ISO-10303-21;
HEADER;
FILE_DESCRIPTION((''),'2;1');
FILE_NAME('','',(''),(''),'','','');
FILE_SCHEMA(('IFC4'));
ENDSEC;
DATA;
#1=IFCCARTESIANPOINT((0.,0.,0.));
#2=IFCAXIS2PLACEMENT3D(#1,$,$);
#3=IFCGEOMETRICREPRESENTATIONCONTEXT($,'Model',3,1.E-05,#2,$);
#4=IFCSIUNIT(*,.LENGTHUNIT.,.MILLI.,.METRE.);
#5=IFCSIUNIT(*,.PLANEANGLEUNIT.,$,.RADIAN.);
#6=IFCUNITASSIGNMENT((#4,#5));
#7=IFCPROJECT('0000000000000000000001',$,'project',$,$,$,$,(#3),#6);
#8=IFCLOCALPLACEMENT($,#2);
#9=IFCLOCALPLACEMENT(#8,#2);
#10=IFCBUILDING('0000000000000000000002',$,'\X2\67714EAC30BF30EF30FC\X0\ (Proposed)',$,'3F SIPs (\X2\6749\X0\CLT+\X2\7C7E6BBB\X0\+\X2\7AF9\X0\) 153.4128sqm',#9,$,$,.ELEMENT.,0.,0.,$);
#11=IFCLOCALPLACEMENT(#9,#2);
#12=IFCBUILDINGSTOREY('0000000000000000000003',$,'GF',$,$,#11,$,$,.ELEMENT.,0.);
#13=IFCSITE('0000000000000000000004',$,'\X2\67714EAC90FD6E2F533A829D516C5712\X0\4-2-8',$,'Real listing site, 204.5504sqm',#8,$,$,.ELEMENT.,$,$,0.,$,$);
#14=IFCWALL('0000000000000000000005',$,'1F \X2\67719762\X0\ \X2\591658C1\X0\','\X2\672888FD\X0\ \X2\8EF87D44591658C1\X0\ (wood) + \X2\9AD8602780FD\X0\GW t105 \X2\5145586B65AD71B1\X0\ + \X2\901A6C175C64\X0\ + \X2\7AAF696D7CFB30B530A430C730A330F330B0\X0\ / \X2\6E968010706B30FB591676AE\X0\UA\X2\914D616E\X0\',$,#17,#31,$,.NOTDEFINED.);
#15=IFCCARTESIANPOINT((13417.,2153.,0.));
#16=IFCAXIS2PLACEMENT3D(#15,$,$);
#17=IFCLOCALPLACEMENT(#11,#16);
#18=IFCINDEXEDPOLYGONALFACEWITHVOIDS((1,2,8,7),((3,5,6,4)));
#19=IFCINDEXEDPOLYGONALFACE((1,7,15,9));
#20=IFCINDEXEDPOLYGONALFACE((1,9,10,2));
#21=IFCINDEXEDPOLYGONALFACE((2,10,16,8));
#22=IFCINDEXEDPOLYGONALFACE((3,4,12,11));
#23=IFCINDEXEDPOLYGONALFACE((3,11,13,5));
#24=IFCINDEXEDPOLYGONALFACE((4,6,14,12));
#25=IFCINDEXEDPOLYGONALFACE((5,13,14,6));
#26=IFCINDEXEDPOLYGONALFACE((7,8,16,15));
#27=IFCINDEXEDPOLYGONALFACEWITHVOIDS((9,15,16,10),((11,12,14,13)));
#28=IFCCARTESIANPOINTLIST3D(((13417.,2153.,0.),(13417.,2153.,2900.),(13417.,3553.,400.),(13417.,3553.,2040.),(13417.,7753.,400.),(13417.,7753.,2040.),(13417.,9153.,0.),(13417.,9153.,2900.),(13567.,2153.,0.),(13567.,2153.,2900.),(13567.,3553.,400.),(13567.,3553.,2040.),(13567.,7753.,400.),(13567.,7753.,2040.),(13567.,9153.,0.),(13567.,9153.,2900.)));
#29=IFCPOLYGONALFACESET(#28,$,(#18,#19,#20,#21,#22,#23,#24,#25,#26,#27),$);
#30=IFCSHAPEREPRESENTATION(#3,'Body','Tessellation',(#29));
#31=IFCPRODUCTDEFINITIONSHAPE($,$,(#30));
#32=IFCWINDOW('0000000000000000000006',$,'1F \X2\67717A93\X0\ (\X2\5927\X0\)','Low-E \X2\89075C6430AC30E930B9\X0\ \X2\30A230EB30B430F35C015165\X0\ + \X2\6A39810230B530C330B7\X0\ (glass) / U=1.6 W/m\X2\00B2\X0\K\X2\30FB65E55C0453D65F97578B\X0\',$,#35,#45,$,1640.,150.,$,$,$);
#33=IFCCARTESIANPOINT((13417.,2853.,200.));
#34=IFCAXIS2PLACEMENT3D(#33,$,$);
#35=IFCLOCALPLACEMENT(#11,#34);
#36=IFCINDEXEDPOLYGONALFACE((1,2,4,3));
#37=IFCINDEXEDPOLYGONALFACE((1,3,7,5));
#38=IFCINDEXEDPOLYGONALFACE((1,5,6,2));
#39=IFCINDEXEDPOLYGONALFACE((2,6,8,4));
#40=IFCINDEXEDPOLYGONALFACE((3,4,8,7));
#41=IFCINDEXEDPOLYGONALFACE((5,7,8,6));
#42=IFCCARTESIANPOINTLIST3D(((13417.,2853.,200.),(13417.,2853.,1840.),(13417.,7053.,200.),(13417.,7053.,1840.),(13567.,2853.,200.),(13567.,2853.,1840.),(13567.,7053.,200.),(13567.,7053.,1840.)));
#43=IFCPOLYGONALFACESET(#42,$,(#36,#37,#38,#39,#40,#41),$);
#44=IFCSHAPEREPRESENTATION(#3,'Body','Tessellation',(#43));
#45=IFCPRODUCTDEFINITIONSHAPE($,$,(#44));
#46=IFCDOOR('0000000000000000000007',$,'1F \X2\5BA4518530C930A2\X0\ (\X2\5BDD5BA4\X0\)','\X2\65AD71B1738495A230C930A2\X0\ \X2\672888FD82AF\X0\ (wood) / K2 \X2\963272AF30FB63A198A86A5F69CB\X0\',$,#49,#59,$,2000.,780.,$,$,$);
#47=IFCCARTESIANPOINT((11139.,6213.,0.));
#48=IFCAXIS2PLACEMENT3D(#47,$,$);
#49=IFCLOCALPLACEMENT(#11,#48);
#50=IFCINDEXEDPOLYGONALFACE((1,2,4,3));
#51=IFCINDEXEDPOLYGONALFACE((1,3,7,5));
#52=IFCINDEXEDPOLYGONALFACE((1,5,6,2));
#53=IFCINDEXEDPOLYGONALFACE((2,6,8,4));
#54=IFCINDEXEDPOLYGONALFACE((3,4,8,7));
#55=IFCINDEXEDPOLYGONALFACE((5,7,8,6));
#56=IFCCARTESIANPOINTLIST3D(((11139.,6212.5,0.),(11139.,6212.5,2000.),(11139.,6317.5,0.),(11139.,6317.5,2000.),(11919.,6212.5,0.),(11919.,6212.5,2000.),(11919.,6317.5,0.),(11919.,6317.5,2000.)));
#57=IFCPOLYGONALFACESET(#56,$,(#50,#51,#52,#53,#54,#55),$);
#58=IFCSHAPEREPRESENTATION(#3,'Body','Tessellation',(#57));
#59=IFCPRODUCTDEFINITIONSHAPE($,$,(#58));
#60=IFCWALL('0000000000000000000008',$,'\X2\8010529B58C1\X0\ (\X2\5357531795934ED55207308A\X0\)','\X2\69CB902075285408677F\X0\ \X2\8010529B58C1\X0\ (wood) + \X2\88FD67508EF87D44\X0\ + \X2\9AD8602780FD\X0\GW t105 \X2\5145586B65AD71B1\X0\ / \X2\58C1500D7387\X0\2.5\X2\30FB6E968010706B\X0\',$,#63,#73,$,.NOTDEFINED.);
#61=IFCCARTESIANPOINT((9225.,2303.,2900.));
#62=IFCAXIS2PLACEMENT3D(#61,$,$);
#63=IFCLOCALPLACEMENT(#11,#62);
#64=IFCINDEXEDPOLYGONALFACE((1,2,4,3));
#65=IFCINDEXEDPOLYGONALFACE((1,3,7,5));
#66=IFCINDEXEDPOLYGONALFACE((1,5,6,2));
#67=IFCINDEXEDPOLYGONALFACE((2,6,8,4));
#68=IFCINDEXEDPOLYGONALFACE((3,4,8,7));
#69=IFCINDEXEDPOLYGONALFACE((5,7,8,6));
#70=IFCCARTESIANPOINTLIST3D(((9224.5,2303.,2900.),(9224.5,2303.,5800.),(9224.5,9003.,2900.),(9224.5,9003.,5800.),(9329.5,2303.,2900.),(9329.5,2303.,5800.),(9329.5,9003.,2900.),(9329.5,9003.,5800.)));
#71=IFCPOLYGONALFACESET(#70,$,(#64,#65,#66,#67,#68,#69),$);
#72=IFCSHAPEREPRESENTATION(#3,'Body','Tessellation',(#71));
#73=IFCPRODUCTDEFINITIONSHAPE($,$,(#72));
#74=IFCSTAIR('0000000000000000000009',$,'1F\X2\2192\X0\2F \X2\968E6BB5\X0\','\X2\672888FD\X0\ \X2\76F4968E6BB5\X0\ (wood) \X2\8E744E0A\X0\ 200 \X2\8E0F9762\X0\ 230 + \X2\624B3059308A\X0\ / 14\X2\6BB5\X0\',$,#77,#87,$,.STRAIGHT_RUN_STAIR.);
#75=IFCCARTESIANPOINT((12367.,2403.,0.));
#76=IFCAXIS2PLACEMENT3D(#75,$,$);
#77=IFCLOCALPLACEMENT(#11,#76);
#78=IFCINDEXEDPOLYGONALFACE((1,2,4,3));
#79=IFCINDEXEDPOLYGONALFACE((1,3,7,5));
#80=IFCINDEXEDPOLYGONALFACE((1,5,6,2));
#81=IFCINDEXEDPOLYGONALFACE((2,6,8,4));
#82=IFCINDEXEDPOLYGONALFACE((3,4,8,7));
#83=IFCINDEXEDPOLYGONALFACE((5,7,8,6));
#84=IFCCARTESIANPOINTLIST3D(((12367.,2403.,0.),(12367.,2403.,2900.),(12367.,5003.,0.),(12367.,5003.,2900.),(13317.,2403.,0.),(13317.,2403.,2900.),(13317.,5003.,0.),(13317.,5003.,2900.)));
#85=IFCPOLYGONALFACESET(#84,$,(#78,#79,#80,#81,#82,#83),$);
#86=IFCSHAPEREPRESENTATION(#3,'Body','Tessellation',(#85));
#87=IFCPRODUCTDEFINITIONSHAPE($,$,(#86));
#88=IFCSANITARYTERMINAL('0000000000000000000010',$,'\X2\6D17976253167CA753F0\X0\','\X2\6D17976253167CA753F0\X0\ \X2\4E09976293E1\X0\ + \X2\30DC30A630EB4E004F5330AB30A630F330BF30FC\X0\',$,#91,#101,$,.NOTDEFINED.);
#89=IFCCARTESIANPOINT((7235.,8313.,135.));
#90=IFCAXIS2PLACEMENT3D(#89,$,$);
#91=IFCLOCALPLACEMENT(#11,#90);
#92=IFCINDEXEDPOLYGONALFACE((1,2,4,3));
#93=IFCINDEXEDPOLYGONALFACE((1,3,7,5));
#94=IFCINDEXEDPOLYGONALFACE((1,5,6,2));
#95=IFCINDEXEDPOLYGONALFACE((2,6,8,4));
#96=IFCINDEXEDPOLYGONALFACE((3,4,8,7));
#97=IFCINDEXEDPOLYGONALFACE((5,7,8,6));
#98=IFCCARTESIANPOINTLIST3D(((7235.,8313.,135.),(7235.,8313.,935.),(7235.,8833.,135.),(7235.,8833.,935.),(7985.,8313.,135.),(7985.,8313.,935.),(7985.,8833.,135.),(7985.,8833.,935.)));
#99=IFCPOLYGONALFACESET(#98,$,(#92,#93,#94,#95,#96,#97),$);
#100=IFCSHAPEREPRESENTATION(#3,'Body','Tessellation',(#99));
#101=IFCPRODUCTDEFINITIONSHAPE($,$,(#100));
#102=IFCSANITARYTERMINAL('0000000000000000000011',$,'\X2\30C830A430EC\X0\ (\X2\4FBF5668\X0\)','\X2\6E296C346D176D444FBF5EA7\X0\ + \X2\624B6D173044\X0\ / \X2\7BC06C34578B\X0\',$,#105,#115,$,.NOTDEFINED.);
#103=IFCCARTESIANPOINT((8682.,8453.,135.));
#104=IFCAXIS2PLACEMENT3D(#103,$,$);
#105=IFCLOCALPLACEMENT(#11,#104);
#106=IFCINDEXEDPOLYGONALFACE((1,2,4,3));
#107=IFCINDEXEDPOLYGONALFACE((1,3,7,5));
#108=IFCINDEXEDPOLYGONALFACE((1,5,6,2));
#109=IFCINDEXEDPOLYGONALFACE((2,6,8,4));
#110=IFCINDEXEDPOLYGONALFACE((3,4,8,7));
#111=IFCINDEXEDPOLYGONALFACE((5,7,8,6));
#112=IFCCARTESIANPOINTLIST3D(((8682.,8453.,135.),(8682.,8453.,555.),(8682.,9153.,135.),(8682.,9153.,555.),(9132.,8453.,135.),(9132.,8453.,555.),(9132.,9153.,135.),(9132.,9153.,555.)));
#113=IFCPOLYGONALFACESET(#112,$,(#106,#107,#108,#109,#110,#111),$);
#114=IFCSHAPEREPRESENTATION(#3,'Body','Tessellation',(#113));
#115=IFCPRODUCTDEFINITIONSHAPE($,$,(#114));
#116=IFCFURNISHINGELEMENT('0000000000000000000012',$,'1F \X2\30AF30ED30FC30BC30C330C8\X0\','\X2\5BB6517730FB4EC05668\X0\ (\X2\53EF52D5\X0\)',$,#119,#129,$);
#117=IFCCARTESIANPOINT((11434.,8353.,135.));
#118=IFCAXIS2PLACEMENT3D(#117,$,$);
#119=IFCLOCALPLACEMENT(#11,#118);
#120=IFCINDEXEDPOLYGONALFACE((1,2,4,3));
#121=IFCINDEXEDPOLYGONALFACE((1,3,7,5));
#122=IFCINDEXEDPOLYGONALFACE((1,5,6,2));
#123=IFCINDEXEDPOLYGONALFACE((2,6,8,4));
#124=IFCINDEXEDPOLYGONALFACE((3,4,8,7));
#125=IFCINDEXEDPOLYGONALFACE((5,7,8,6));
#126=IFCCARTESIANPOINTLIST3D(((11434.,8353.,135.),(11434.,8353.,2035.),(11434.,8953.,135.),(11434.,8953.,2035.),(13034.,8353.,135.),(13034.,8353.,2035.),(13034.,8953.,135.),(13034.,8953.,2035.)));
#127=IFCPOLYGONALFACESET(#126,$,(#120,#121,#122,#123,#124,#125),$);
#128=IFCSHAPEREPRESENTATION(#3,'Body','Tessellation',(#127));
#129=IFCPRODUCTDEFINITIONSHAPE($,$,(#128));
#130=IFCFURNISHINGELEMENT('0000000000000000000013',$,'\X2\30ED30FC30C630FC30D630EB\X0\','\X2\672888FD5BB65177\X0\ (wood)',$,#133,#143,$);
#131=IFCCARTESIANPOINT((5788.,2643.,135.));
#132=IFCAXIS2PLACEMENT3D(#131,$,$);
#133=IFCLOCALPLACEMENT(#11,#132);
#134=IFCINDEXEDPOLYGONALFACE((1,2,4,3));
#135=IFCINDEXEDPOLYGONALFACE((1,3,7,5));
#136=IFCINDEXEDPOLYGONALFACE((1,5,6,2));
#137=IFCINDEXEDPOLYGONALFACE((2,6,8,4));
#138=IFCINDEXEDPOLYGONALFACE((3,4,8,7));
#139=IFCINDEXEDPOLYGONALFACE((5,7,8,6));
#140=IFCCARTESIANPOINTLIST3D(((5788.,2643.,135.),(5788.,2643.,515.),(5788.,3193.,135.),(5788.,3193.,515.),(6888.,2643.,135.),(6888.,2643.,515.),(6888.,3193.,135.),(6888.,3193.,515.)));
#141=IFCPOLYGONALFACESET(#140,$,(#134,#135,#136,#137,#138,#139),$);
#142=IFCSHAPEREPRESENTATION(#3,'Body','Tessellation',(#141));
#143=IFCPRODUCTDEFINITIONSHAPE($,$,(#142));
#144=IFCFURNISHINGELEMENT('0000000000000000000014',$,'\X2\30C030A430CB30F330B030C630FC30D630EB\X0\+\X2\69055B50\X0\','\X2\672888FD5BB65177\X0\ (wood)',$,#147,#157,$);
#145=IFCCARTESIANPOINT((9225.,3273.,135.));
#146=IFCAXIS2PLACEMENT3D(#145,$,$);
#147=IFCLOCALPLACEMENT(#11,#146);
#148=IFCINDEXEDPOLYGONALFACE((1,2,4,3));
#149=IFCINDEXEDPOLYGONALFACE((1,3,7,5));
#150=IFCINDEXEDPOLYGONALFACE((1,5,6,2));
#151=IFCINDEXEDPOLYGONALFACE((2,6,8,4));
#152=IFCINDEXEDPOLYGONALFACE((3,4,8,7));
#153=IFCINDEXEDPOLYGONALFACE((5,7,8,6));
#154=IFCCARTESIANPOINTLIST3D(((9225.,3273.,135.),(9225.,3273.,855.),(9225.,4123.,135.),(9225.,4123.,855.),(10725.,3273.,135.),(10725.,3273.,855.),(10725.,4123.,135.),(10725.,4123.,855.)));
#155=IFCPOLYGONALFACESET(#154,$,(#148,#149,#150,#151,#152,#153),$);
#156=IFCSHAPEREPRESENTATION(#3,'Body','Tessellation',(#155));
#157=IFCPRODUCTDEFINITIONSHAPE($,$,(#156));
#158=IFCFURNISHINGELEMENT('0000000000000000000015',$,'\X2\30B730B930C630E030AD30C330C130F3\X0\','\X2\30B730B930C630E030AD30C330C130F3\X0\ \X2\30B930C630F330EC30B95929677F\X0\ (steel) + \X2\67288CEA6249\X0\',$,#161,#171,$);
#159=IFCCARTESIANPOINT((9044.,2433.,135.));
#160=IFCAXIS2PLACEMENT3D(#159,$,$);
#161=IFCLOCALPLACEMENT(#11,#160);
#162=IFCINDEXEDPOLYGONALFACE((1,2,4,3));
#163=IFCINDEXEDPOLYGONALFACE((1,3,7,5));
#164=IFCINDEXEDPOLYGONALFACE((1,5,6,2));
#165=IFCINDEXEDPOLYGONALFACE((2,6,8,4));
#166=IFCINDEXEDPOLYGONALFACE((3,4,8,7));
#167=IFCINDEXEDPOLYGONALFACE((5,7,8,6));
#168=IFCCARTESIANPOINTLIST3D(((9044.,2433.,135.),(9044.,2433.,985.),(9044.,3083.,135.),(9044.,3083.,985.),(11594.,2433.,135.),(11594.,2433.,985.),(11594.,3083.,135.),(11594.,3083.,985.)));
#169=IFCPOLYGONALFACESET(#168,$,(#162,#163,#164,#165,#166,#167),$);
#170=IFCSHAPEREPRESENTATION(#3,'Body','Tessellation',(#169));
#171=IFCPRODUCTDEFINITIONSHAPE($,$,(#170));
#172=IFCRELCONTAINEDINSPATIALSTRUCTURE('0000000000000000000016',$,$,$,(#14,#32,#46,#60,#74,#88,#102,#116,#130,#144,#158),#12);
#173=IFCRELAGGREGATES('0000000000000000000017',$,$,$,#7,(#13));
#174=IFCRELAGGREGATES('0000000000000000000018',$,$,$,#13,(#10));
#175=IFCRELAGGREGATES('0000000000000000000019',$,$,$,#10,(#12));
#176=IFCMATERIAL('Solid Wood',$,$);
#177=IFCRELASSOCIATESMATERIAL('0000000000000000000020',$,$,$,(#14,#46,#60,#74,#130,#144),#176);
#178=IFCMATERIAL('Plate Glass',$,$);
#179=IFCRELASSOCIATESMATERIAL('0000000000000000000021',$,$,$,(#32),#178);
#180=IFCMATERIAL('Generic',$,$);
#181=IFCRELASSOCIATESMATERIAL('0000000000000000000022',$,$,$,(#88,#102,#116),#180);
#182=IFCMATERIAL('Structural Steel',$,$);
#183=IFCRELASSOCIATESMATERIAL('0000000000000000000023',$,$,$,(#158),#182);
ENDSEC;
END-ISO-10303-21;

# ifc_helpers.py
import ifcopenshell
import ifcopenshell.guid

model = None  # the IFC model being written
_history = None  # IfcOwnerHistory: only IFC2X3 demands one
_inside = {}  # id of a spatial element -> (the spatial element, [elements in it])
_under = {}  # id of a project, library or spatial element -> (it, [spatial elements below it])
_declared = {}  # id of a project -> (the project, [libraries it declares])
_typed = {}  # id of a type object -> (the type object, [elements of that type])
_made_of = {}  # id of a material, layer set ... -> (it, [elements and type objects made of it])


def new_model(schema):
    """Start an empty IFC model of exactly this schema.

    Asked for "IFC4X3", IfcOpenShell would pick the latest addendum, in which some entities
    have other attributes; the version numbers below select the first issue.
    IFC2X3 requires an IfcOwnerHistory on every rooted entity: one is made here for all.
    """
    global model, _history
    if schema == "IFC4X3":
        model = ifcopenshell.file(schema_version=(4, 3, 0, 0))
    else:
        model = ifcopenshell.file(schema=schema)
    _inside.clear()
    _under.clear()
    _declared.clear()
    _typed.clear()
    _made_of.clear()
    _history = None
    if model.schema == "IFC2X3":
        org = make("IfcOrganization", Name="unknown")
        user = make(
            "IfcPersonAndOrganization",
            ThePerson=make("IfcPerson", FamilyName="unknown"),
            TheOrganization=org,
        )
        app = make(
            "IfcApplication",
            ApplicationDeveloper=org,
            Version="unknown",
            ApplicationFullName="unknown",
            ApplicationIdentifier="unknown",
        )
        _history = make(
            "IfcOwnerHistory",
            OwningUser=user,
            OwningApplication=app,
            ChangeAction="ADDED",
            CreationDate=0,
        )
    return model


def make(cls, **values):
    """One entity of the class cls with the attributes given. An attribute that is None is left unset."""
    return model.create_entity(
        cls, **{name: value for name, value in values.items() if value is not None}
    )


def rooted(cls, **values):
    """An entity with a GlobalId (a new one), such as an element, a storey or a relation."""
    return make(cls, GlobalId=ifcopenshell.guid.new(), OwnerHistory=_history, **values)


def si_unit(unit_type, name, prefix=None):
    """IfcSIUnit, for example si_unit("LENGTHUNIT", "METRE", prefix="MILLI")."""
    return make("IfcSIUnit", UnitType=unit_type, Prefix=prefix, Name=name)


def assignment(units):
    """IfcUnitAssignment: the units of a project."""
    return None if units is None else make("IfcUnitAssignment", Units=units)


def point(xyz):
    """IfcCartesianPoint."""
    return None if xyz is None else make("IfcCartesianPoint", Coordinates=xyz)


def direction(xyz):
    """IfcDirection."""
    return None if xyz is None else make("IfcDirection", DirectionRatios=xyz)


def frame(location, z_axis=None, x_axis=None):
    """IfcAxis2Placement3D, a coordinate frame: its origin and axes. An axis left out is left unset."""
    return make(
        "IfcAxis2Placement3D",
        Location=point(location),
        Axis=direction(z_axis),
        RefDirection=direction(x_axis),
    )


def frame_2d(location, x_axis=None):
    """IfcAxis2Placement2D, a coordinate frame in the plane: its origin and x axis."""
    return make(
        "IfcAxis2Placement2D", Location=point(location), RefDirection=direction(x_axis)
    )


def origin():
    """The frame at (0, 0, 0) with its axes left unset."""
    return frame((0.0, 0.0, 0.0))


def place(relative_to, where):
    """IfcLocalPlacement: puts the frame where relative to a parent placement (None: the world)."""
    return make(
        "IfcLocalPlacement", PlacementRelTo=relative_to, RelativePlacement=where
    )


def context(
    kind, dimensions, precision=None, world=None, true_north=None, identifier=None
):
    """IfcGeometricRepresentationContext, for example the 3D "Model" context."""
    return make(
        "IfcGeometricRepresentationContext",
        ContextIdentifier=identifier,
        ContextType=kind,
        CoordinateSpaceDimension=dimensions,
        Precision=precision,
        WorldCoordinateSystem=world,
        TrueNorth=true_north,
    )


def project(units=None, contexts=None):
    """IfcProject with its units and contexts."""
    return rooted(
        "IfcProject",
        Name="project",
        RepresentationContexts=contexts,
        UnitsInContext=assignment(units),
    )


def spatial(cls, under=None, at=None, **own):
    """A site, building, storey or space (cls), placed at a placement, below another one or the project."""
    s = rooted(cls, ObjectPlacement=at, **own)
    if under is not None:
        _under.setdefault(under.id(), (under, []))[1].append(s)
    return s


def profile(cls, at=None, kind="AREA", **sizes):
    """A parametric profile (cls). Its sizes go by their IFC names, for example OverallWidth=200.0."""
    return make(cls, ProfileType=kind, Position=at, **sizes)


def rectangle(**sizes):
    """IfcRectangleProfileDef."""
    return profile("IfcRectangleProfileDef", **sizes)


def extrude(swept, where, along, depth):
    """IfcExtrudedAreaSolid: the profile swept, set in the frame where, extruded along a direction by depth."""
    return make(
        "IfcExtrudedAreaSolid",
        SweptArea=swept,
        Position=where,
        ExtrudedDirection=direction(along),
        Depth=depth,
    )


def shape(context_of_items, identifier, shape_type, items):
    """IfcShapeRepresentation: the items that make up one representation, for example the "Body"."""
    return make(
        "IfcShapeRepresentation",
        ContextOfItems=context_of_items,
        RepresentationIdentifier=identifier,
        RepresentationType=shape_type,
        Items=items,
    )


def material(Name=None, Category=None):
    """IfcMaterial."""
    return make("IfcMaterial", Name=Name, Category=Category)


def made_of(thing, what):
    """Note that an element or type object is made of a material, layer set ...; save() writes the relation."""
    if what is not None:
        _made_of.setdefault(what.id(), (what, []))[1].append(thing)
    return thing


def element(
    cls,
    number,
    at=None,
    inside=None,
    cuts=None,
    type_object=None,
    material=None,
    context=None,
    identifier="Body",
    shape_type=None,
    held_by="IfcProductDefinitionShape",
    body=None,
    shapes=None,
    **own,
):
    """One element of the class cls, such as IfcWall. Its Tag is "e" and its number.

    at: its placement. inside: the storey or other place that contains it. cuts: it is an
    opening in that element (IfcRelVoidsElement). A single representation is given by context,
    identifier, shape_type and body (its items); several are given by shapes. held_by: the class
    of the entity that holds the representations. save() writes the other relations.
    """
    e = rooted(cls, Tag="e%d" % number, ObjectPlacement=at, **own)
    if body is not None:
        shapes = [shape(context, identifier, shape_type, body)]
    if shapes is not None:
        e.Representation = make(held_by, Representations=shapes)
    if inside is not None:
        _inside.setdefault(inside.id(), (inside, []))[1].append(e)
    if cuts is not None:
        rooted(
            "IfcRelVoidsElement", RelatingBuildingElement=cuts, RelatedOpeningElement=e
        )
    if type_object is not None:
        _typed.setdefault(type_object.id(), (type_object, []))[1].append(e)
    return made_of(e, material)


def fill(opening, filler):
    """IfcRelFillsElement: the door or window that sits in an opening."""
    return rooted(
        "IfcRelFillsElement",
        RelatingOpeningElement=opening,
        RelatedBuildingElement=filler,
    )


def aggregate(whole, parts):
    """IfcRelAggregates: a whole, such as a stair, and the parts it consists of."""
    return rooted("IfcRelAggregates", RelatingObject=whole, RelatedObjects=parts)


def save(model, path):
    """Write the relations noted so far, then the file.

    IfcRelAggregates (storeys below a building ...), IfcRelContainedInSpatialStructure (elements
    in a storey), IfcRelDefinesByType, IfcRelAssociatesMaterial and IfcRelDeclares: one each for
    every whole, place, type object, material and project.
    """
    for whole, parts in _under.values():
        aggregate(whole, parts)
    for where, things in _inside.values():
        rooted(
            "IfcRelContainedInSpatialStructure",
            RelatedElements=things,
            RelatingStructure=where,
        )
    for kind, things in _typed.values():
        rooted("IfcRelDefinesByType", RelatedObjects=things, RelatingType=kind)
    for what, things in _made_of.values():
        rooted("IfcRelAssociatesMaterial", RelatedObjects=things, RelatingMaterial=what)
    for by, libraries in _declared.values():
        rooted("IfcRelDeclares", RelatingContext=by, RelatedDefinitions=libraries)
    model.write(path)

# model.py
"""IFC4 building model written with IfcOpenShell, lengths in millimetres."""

from ifc_helpers import new_model, si_unit, frame, frame_2d, origin, place, context, project, spatial, rectangle, extrude, material, element, fill, save


model = new_model("IFC4")

# Units and contexts
model_context = context("Model", 3, precision=1e-05, world=origin())
ifc_project = project(units=[si_unit("LENGTHUNIT", "METRE", prefix="MILLI"), si_unit("PLANEANGLEUNIT", "RADIAN")], contexts=[model_context])

# Site, building, storey
site_placement = place(None, origin())
site = spatial("IfcSite", under=ifc_project, at=site_placement, Name="東京都港区芝公園4-2-8", ObjectType="Real listing site, 204.5504sqm", CompositionType="ELEMENT", RefElevation=0.0)
building_placement = place(site_placement, origin())
building = spatial("IfcBuilding", under=site, at=building_placement, Name="東京タワー (Proposed)", ObjectType="3F SIPs (杉CLT+籾殻+竹) 153.4128sqm", CompositionType="ELEMENT", ElevationOfRefHeight=0.0, ElevationOfTerrain=0.0)
storey_placement = place(building_placement, origin())
storey = spatial("IfcBuildingStorey", under=building, at=storey_placement, Name="GF", CompositionType="ELEMENT", Elevation=0.0)

# Wall, opening, window
ifc_material_1 = material(Name="Solid Wood")
wall_1_placement = place(storey_placement, frame((13417.0, 2153.0, 0.0)))
wall_1 = element("IfcWall", 1, at=wall_1_placement, inside=storey, material=ifc_material_1, Name="1F 東面 外壁", Description="木製 軸組外壁 (wood) + 高性能GW t105 充填断熱 + 通気層 + 窯業系サイディング / 準耐火・外皮UA配慮", PredefinedType="NOTDEFINED", context=model_context, shape_type="SweptSolid", body=[
    extrude(rectangle(XDim=150.0, YDim=7000.0, at=frame_2d((75.0, 3500.0))), frame((13417.0, 2153.0, 0.0)), (0.0, 0.0, 1.0), 2900.0),
])
opening_placement = place(storey_placement, frame((13417.0, 2853.0, 200.0)))
opening = element("IfcOpeningElement", 2, at=opening_placement, cuts=wall_1, PredefinedType="NOTDEFINED", context=model_context, shape_type="SweptSolid", body=[
    extrude(rectangle(XDim=150.0, YDim=4200.0, at=frame_2d((75.0, 2100.0))), frame((13417.0, 2853.0, 200.0)), (0.0, 0.0, 1.0), 1640.0),
])
ifc_material_2 = material(Name="Plate Glass")
window_placement = place(storey_placement, frame((13417.0, 2853.0, 200.0)))
window = element("IfcWindow", 3, at=window_placement, inside=storey, material=ifc_material_2, Name="1F 東窓 (大)", Description="Low-E 複層ガラス アルゴン封入 + 樹脂サッシ (glass) / U=1.6 W/m²K・日射取得型", OverallHeight=1640.0, OverallWidth=150.0, context=model_context, shape_type="SweptSolid", body=[
    extrude(rectangle(XDim=150.0, YDim=4200.0, at=frame_2d((75.0, 2100.0))), frame((13417.0, 2853.0, 200.0)), (0.0, 0.0, 1.0), 1640.0),
])
fill(opening, window)

# Door
door_placement = place(storey_placement, frame((11139.0, 6213.0, 0.0)))
element("IfcDoor", 4, at=door_placement, inside=storey, material=ifc_material_1, Name="1F 室内ドア (寝室)", Description="断熱玄関ドア 木製芯 (wood) / K2 防犯・採風機構", OverallHeight=2000.0, OverallWidth=780.0, context=model_context, shape_type="SweptSolid", body=[
    extrude(rectangle(XDim=780.0, YDim=105.0, at=frame_2d((390.0, 52.0))), frame((11139.0, 6213.0, 0.0)), (0.0, 0.0, 1.0), 2000.0),
])

# Wall
wall_2_placement = place(storey_placement, frame((9225.0, 2303.0, 2900.0)))
element("IfcWall", 5, at=wall_2_placement, inside=storey, material=ifc_material_1, Name="耐力壁 (南北間仕切り)", Description="構造用合板 耐力壁 (wood) + 製材軸組 + 高性能GW t105 充填断熱 / 壁倍率2.5・準耐火", PredefinedType="NOTDEFINED", context=model_context, shape_type="SweptSolid", body=[
    extrude(rectangle(XDim=105.0, YDim=6700.0, at=frame_2d((52.0, 3350.0))), frame((9225.0, 2303.0, 2900.0)), (0.0, 0.0, 1.0), 2900.0),
])

# Stair
stair_placement = place(storey_placement, frame((12367.0, 2403.0, 0.0)))
element("IfcStair", 6, at=stair_placement, inside=storey, material=ifc_material_1, Name="1F→2F 階段", Description="木製 直階段 (wood) 蹴上 200 踏面 230 + 手すり / 14段", PredefinedType="STRAIGHT_RUN_STAIR", context=model_context, shape_type="SweptSolid", body=[
    extrude(rectangle(XDim=950.0, YDim=2600.0, at=frame_2d((475.0, 1300.0))), frame((12367.0, 2403.0, 0.0)), (0.0, 0.0, 1.0), 2900.0),
])

# Sanitary terminals
ifc_material_3 = material(Name="Generic")
sanitary_terminal_1_placement = place(storey_placement, frame((7235.0, 8313.0, 135.0)))
element("IfcSanitaryTerminal", 7, at=sanitary_terminal_1_placement, inside=storey, material=ifc_material_3, Name="洗面化粧台", Description="洗面化粧台 三面鏡 + ボウル一体カウンター", PredefinedType="NOTDEFINED", context=model_context, shape_type="SweptSolid", body=[
    extrude(rectangle(XDim=750.0, YDim=520.0, at=frame_2d((375.0, 260.0))), frame((7235.0, 8313.0, 135.0)), (0.0, 0.0, 1.0), 800.0),
])
sanitary_terminal_2_placement = place(storey_placement, frame((8682.0, 8453.0, 135.0)))
element("IfcSanitaryTerminal", 8, at=sanitary_terminal_2_placement, inside=storey, material=ifc_material_3, Name="トイレ (便器)", Description="温水洗浄便座 + 手洗い / 節水型", PredefinedType="NOTDEFINED", context=model_context, shape_type="SweptSolid", body=[
    extrude(rectangle(XDim=450.0, YDim=700.0, at=frame_2d((225.0, 350.0))), frame((8682.0, 8453.0, 135.0)), (0.0, 0.0, 1.0), 420.0),
])

# Furnishing elements
furnishing_1_placement = place(storey_placement, frame((11434.0, 8353.0, 135.0)))
element("IfcFurnishingElement", 9, at=furnishing_1_placement, inside=storey, material=ifc_material_3, Name="1F クローゼット", Description="家具・什器 (可動)", context=model_context, shape_type="SweptSolid", body=[
    extrude(rectangle(XDim=1600.0, YDim=600.0, at=frame_2d((800.0, 300.0))), frame((11434.0, 8353.0, 135.0)), (0.0, 0.0, 1.0), 1900.0),
])
furnishing_2_placement = place(storey_placement, frame((5788.0, 2643.0, 135.0)))
element("IfcFurnishingElement", 10, at=furnishing_2_placement, inside=storey, material=ifc_material_1, Name="ローテーブル", Description="木製家具 (wood)", context=model_context, shape_type="SweptSolid", body=[
    extrude(rectangle(XDim=1100.0, YDim=550.0, at=frame_2d((550.0, 275.0))), frame((5788.0, 2643.0, 135.0)), (0.0, 0.0, 1.0), 380.0),
])
furnishing_3_placement = place(storey_placement, frame((9225.0, 3273.0, 135.0)))
element("IfcFurnishingElement", 11, at=furnishing_3_placement, inside=storey, material=ifc_material_1, Name="ダイニングテーブル+椅子", Description="木製家具 (wood)", context=model_context, shape_type="SweptSolid", body=[
    extrude(rectangle(XDim=1500.0, YDim=850.0, at=frame_2d((750.0, 425.0))), frame((9225.0, 3273.0, 135.0)), (0.0, 0.0, 1.0), 720.0),
])
ifc_material_4 = material(Name="Structural Steel")
furnishing_4_placement = place(storey_placement, frame((9044.0, 2433.0, 135.0)))
element("IfcFurnishingElement", 12, at=furnishing_4_placement, inside=storey, material=ifc_material_4, Name="システムキッチン", Description="システムキッチン ステンレス天板 (steel) + 木質扉", context=model_context, shape_type="SweptSolid", body=[
    extrude(rectangle(XDim=2550.0, YDim=650.0, at=frame_2d((1275.0, 325.0))), frame((9044.0, 2433.0, 135.0)), (0.0, 0.0, 1.0), 850.0),
])

save(model, "model.ifc")
